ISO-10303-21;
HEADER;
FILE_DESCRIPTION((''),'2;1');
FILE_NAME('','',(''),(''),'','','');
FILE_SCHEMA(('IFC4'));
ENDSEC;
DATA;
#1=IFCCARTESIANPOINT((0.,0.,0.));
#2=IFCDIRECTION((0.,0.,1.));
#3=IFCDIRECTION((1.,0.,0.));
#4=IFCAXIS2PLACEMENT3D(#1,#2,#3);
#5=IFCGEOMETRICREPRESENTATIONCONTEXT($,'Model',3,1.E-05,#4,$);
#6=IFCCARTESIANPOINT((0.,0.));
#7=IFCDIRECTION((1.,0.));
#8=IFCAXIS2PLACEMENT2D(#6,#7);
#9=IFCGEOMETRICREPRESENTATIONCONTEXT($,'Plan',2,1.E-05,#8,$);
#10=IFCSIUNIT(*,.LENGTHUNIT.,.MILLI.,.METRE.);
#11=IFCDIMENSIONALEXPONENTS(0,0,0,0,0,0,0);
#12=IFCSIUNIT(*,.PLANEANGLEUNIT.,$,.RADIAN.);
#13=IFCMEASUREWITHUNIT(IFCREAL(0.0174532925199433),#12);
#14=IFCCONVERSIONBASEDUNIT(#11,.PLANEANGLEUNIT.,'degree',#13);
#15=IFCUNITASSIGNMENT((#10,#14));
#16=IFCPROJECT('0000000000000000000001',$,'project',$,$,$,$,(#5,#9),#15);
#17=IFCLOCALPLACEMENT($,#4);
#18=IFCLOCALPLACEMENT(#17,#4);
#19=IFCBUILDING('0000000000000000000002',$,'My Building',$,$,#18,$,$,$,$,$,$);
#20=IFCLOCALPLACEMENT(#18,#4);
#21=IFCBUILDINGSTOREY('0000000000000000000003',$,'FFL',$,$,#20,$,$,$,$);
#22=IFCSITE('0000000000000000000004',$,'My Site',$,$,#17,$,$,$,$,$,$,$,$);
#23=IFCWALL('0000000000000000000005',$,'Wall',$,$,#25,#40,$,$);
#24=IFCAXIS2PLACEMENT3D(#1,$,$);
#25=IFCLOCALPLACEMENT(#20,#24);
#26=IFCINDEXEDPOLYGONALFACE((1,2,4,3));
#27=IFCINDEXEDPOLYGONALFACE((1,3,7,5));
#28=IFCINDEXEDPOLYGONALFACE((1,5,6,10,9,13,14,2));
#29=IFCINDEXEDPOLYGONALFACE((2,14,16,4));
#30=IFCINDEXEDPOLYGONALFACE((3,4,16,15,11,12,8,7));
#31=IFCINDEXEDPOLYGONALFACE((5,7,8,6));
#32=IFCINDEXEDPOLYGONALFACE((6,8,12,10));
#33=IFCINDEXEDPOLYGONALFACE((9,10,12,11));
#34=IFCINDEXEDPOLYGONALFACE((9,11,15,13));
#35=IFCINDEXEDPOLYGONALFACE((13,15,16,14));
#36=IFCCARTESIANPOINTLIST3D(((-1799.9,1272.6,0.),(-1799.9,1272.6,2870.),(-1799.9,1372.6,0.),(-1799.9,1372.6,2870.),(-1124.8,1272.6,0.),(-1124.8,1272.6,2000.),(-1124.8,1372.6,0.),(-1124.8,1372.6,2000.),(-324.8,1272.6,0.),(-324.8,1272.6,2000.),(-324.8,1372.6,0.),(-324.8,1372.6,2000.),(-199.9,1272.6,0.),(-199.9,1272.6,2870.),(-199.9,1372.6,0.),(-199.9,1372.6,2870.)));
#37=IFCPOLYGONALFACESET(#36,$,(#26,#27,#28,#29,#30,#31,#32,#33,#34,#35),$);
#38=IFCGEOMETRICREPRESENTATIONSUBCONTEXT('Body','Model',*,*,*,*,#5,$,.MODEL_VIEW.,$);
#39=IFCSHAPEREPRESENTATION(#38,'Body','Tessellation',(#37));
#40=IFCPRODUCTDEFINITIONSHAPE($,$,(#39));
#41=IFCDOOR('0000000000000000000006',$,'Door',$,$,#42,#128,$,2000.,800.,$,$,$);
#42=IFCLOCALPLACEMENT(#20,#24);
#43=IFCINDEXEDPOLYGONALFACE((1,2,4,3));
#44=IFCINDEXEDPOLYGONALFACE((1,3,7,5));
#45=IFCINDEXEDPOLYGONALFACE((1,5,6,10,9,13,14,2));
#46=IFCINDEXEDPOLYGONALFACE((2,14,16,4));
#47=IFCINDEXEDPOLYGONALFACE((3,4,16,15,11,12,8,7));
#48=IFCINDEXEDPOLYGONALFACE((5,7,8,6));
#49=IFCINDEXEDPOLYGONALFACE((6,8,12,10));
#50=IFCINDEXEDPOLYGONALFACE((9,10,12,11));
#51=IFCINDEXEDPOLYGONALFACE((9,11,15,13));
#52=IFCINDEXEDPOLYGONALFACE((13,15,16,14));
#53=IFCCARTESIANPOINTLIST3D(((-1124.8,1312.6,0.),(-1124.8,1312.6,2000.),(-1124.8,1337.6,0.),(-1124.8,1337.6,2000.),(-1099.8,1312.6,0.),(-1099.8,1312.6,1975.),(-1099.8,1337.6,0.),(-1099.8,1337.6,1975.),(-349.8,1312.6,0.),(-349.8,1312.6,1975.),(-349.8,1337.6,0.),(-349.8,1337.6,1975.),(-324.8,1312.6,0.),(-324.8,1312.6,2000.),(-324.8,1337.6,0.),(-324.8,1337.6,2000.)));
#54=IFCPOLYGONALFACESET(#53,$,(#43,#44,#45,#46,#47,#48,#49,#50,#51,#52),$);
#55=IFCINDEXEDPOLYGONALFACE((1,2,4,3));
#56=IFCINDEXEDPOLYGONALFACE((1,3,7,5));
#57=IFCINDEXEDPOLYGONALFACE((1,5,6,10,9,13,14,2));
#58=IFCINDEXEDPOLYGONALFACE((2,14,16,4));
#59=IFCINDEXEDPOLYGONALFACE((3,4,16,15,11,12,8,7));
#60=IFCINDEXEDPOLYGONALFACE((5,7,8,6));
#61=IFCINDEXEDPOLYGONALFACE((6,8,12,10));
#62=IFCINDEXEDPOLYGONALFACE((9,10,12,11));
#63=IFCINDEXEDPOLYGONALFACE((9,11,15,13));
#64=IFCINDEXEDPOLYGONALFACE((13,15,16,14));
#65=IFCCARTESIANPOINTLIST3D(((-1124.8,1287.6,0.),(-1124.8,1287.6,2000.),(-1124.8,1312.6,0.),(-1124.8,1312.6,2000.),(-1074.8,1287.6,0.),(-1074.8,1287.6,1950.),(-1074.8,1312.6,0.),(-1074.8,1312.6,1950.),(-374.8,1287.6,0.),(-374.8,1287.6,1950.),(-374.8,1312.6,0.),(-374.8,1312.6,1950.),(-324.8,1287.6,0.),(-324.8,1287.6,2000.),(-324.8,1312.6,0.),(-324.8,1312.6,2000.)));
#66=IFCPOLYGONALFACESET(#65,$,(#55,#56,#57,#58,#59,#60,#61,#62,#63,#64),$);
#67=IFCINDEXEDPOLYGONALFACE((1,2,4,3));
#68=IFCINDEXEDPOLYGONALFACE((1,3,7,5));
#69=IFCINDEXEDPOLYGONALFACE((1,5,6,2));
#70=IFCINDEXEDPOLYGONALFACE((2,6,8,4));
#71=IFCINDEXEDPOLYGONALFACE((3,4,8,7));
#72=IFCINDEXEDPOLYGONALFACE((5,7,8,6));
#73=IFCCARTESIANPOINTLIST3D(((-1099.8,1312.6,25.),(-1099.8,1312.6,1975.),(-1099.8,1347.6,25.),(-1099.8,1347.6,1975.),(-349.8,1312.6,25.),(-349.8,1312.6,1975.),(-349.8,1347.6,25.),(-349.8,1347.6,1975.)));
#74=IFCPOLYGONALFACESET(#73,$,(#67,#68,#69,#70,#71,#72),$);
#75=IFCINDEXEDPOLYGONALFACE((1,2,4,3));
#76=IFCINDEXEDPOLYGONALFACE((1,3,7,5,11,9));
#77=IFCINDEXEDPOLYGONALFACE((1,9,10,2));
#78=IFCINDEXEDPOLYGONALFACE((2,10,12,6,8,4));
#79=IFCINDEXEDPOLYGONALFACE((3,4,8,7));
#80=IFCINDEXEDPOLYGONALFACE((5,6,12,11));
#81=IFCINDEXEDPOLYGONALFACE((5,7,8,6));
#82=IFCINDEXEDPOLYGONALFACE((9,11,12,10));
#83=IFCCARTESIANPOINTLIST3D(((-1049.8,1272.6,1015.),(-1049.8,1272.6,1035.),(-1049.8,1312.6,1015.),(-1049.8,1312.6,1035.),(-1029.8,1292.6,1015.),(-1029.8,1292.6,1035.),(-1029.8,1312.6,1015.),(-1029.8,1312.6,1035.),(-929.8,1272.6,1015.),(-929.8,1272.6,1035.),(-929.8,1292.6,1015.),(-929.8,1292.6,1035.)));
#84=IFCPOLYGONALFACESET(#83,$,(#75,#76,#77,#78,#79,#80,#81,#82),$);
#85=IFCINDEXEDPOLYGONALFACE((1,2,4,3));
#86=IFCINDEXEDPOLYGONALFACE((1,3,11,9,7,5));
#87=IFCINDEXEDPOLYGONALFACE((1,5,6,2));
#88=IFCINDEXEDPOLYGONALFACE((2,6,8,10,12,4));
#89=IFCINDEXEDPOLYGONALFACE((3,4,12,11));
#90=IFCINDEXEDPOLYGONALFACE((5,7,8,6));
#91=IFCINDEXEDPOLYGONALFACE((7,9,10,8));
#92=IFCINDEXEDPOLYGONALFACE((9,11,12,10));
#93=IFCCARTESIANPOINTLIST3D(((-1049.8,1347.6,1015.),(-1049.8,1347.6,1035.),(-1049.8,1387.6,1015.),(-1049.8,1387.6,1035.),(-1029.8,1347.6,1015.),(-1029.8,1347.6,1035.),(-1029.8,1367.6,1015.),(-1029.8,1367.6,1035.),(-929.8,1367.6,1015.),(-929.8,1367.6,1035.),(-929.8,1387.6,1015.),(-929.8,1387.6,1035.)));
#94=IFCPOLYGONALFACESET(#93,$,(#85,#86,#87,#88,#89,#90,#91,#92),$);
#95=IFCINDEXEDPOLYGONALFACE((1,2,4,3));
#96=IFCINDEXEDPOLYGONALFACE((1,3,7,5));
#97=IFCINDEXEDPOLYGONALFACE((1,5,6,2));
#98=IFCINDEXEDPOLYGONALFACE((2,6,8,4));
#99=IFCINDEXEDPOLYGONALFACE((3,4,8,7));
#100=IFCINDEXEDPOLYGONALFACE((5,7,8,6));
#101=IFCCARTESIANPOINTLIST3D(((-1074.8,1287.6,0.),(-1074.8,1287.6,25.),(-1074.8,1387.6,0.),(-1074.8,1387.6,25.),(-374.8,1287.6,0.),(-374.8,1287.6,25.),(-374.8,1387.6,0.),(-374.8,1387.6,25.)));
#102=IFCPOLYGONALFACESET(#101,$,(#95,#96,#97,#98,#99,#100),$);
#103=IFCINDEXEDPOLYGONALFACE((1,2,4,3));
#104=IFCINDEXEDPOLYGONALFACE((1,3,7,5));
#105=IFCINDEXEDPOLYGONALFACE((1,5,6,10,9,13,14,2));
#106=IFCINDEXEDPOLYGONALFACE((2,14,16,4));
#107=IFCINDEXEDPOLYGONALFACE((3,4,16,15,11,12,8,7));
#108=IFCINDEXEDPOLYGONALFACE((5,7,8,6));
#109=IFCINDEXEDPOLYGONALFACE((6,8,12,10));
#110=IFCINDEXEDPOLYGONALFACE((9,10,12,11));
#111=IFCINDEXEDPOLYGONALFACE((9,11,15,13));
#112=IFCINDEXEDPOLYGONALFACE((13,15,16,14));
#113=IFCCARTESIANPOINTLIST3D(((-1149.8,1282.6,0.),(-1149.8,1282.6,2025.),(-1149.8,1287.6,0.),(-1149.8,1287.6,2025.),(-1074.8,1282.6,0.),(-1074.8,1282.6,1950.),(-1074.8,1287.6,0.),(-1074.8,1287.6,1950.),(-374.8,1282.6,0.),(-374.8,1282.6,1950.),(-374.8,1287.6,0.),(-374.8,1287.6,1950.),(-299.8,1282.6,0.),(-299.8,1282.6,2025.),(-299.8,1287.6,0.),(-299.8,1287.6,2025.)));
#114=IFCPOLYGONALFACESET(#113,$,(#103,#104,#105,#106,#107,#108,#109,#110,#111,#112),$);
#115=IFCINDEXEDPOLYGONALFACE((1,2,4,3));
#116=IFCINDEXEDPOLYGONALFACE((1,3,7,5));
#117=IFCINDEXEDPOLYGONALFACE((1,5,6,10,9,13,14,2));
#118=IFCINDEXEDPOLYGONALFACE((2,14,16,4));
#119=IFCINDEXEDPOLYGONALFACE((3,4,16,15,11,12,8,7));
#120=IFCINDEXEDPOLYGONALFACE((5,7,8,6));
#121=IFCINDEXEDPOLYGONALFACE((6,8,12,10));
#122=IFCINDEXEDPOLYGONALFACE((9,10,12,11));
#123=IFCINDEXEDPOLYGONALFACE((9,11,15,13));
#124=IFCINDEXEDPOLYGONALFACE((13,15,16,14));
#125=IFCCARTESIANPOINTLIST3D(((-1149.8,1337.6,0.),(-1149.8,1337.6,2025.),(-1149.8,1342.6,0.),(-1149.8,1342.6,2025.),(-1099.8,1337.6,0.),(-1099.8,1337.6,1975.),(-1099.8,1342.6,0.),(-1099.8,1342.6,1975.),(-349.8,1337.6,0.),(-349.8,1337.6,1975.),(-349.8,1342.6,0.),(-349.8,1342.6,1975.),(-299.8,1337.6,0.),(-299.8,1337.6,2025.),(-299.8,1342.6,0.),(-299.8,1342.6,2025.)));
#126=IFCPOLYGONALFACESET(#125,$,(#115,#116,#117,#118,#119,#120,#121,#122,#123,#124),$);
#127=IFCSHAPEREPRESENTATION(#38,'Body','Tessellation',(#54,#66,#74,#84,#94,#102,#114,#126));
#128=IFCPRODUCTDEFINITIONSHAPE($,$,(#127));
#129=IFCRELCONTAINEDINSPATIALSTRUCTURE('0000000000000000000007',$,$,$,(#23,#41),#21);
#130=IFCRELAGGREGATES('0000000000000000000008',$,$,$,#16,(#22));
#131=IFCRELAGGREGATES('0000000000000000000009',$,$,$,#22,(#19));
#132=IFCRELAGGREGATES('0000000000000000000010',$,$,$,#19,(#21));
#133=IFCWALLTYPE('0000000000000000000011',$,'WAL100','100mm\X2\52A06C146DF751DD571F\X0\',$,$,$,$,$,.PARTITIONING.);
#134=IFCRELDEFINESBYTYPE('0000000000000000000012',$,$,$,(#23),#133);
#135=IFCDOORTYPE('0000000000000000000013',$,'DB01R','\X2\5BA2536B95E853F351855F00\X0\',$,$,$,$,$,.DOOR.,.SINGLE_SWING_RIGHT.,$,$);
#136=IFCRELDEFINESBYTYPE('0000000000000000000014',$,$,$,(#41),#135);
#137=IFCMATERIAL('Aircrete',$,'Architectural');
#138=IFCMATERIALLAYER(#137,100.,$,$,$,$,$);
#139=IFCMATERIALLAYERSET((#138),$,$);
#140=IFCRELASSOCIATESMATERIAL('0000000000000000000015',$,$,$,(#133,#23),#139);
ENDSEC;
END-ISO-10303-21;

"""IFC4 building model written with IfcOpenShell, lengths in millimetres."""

from ifc_helpers import new_model, entity, si_unit, converted_unit, frame, origin_with_axes, origin_2d_with_axis, place, context, subcontext, project, spatial, line, indexed_curve, outline, extrude, shape, source, transform, mapped, material, layer, layer_set, layer_usage, type_object, type_shapes, element, fill, save


model = new_model("IFC4")

# Units and contexts
model_context = context("Model", 3, precision=1e-05, world=origin_with_axes())
plan_context = context("Plan", 2, precision=1e-05, world=origin_2d_with_axis())
body_context_1 = subcontext(model_context, "Body", "Model", "MODEL_VIEW")
body_context_2 = subcontext(plan_context, "Body", "Plan", "PLAN_VIEW")
ifc_project = project(units=[si_unit("LENGTHUNIT", "METRE", prefix="MILLI"), converted_unit("PLANEANGLEUNIT", "degree", entity("IfcReal", 0.0174532925199433), si_unit("PLANEANGLEUNIT", "RADIAN"), dimensions=[0, 0, 0, 0, 0, 0, 0])], contexts=[model_context, plan_context])

# Site, building, storey
site_placement = place(None, origin_with_axes())
site = spatial("IfcSite", under=ifc_project, at=site_placement, Name="My Site")
building_placement = place(site_placement, origin_with_axes())
building = spatial("IfcBuilding", under=site, at=building_placement, Name="My Building")
storey_placement = place(building_placement, origin_with_axes())
storey = spatial("IfcBuildingStorey", under=building, at=storey_placement, Name="FFL")

# Shared definitions
ifc_material_1 = material(Name="Aircrete", Category="Architectural")

# Wall, openings, door
ifc_layer_1 = layer(ifc_material_1, 100.0)
ifc_layer_set_1 = layer_set([ifc_layer_1])
ifc_layer_usage_1 = layer_usage(ifc_layer_set_1, "AXIS2", "POSITIVE", 0.0)
wall_type_1 = type_object("IfcWallType", Name="WAL100", Description="100mm加气混凝土", PredefinedType="PARTITIONING", material=ifc_layer_set_1)
wall_1_placement = place(storey_placement, frame((-199.9, 1372.6, 0.0), z_axis=(0.0, 0.0, 1.0), x_axis=(-1.0, 0.0, 0.0)))
wall_1 = element("IfcWall", 1, at=wall_1_placement, inside=storey, type_object=wall_type_1, material=ifc_layer_usage_1, Name="Wall", context=body_context_1, shape_type="SweptSolid", body=[
    extrude(outline(indexed_curve([(0.0, 0.0), (0.0, 100.0), (1600.0, 100.0), (1600.0, 0.0)], segments=[line(1, 2, 3, 4, 1)])), origin_with_axes(), (0.0, 0.0, 1.0), 2870.0),
])
shared_shape_1 = source(origin_with_axes(), body_context_1, "Body", "SweptSolid", [
    extrude(outline(indexed_curve([(0.0, 0.0), (800.0, 0.0), (800.0, 2000.0), (0.0, 2000.0)], segments=[line(1, 2, 3, 4, 1)])), frame((0.0, -600.0, 0.0), z_axis=(0.0, -1.0, 0.0), x_axis=(1.0, 0.0, 0.0)), (0.0, 0.0, -1.0), 1200.0),
])
opening_1_placement = place(wall_1_placement, frame((924.9, 85.0, 0.0), z_axis=(0.0, 0.0, 1.0), x_axis=(-1.0, 0.0, 0.0)))
opening_1 = element("IfcOpeningElement", 2, at=opening_1_placement, cuts=wall_1, PredefinedType="OPENING", context=body_context_1, shape_type="MappedRepresentation", body=[
    mapped(shared_shape_1, transform((0.0, 0.0, 0.0), x_axis=(1.0, 0.0, 0.0), y_axis=(0.0, 1.0, 0.0), z_axis=(0.0, 0.0, 1.0), scale=1.0)),
])
door_type_1 = type_object("IfcDoorType", Name="DB01R", Description="客卫门右内开", OperationType="SINGLE_SWING_RIGHT", PredefinedType="DOOR")
shared_shape_2 = source(origin_with_axes(), body_context_1, "Body", "SweptSolid", [
    extrude(outline(indexed_curve([(0.0, 0.0), (0.0, 2000.0), (800.0, 2000.0), (800.0, 0.0), (775.0, 0.0), (775.0, 1975.0), (25.0, 1975.0), (25.0, 0.0)], segments=[line(1, 2, 3, 4, 5, 6, 7, 8, 1)])), frame((0.0, 25.0, 0.0), z_axis=(0.0, -1.0, 0.0), x_axis=(1.0, 0.0, 0.0)), (0.0, 0.0, -1.0), 25.0),
    extrude(outline(indexed_curve([(0.0, 0.0), (0.0, 2000.0), (800.0, 2000.0), (800.0, 0.0), (750.0, 0.0), (750.0, 1950.0), (50.0, 1950.0), (50.0, 0.0)], segments=[line(1, 2, 3, 4, 5, 6, 7, 8, 1)])), frame((0.0, 0.0, 0.0), z_axis=(0.0, -1.0, 0.0), x_axis=(1.0, 0.0, 0.0)), (0.0, 0.0, -1.0), 25.0),
    extrude(outline(indexed_curve([(0.0, 0.0), (750.0, 0.0), (750.0, 35.0), (0.0, 35.0)], segments=[line(1, 2, 3, 4, 1)])), frame((25.0, 25.0, 25.0), z_axis=(0.0, 0.0, 1.0), x_axis=(1.0, 0.0, 0.0)), (0.0, 0.0, 1.0), 1950.0),
    extrude(outline(indexed_curve([(0.0, 0.0), (0.0, -40.0), (120.0, -40.0), (120.0, -20.0), (20.0, -20.0), (20.0, 0.0)], segments=[line(1, 2, 3, 4, 5, 6, 1)])), frame((75.0, 25.0, 1015.0), z_axis=(0.0, 0.0, 1.0), x_axis=(1.0, 0.0, 0.0)), (0.0, 0.0, 1.0), 20.0),
    extrude(outline(indexed_curve([(0.0, 0.0), (0.0, 40.0), (120.0, 40.0), (120.0, 20.0), (20.0, 20.0), (20.0, 0.0)], segments=[line(1, 2, 3, 4, 5, 6, 1)])), frame((75.0, 60.0, 1015.0), z_axis=(0.0, 0.0, 1.0), x_axis=(1.0, 0.0, 0.0)), (0.0, 0.0, 1.0), 20.0),
    extrude(outline(indexed_curve([(0.0, 0.0), (700.0, 0.0), (700.0, 100.0), (0.0, 100.0)], segments=[line(1, 2, 3, 4, 1)])), frame((50.0, 0.0, 0.0), z_axis=(0.0, 0.0, 1.0), x_axis=(1.0, 0.0, 0.0)), (0.0, 0.0, 1.0), 25.0),
    extrude(outline(indexed_curve([(0.0, 0.0), (0.0, 2025.0), (850.0, 2025.0), (850.0, 0.0), (775.0, 0.0), (775.0, 1950.0), (75.0, 1950.0), (75.0, 0.0)], segments=[line(1, 2, 3, 4, 5, 6, 7, 8, 1)])), frame((-25.0, -5.0, 0.0), z_axis=(0.0, -1.0, 0.0), x_axis=(1.0, 0.0, 0.0)), (0.0, 0.0, -1.0), 5.0),
    extrude(outline(indexed_curve([(0.0, 0.0), (0.0, 2025.0), (850.0, 2025.0), (850.0, 0.0), (800.0, 0.0), (800.0, 1975.0), (50.0, 1975.0), (50.0, 0.0)], segments=[line(1, 2, 3, 4, 5, 6, 7, 8, 1)])), frame((-25.0, 50.0, 0.0), z_axis=(0.0, -1.0, 0.0), x_axis=(1.0, 0.0, 0.0)), (0.0, 0.0, -1.0), 5.0),
])
shared_shape_3 = source(origin_with_axes(), body_context_2, "Body", "Curve2D", [
    entity("IfcIndexedPolyCurve", entity("IfcCartesianPointList2D", [[0.0, 0.0], [0.0, 50.0], [25.0, 50.0], [25.0, 25.0], [50.0, 25.0], [50.0, 0.0]]), [entity("IfcLineIndex", [1, 2, 3, 4, 5, 6, 1])]),
    entity("IfcIndexedPolyCurve", entity("IfcCartesianPointList2D", [[800.0, 0.0], [800.0, 50.0], [775.0, 50.0], [775.0, 25.0], [750.0, 25.0], [750.0, 0.0]]), [entity("IfcLineIndex", [1, 2, 3, 4, 5, 6, 1])]),
    entity("IfcTrimmedCurve", entity("IfcEllipse", entity("IfcAxis2Placement2D", entity("IfcCartesianPoint", [740.0, 50.0]), entity("IfcDirection", [1.0, 0.0])), 715.0, 750.0), [entity("IfcCartesianPoint", [740.0, 800.0])], [entity("IfcCartesianPoint", [25.0, 50.0])], True, "CARTESIAN"),
    entity("IfcIndexedPolyCurve", entity("IfcCartesianPointList2D", [[775.0, 50.0], [740.0, 50.0], [740.0, 800.0], [775.0, 800.0]]), [entity("IfcLineIndex", [1, 2, 3, 4, 1])]),
])
type_shapes(door_type_1, [shared_shape_2, shared_shape_3])
door_1_placement = place(opening_1_placement, frame((0.0, 0.0, 0.0), z_axis=(0.0, 0.0, 1.0), x_axis=(1.0, 0.0, 0.0)))
door_1 = element("IfcDoor", 3, at=door_1_placement, inside=storey, type_object=door_type_1, Name="Door", OverallHeight=2000.0, OverallWidth=800.0, shapes=[
    shape(body_context_1, "Body", "MappedRepresentation", [mapped(shared_shape_2, transform((0.0, 0.0, 0.0), x_axis=(1.0, 0.0, 0.0), y_axis=(0.0, 1.0, 0.0), z_axis=(0.0, 0.0, 1.0), scale=1.0))]),
    shape(body_context_2, "Body", "MappedRepresentation", [mapped(shared_shape_3, transform((0.0, 0.0, 0.0), x_axis=(1.0, 0.0, 0.0), y_axis=(0.0, 1.0, 0.0), z_axis=(0.0, 0.0, 1.0), scale=1.0))]),
])
fill(opening_1, door_1)
opening_2_placement = place(door_1_placement, frame((1600.1, 1172.5, 0.0), z_axis=(0.0, 0.0, 1.0), x_axis=(-1.0, 0.0, 0.0)))
element("IfcOpeningElement", 4, at=opening_2_placement, cuts=door_1, PredefinedType="OPENING", context=body_context_1, shape_type="SweptSolid", body=[
    extrude(outline(indexed_curve([(0.0, 0.0), (500.0, 0.0), (500.0, 500.0), (0.0, 500.0)], segments=[line(1, 2, 3, 4, 1)])), origin_with_axes(), (0.0, 0.0, 1.0), 500.0),
])

save(model, "model.ifc")
